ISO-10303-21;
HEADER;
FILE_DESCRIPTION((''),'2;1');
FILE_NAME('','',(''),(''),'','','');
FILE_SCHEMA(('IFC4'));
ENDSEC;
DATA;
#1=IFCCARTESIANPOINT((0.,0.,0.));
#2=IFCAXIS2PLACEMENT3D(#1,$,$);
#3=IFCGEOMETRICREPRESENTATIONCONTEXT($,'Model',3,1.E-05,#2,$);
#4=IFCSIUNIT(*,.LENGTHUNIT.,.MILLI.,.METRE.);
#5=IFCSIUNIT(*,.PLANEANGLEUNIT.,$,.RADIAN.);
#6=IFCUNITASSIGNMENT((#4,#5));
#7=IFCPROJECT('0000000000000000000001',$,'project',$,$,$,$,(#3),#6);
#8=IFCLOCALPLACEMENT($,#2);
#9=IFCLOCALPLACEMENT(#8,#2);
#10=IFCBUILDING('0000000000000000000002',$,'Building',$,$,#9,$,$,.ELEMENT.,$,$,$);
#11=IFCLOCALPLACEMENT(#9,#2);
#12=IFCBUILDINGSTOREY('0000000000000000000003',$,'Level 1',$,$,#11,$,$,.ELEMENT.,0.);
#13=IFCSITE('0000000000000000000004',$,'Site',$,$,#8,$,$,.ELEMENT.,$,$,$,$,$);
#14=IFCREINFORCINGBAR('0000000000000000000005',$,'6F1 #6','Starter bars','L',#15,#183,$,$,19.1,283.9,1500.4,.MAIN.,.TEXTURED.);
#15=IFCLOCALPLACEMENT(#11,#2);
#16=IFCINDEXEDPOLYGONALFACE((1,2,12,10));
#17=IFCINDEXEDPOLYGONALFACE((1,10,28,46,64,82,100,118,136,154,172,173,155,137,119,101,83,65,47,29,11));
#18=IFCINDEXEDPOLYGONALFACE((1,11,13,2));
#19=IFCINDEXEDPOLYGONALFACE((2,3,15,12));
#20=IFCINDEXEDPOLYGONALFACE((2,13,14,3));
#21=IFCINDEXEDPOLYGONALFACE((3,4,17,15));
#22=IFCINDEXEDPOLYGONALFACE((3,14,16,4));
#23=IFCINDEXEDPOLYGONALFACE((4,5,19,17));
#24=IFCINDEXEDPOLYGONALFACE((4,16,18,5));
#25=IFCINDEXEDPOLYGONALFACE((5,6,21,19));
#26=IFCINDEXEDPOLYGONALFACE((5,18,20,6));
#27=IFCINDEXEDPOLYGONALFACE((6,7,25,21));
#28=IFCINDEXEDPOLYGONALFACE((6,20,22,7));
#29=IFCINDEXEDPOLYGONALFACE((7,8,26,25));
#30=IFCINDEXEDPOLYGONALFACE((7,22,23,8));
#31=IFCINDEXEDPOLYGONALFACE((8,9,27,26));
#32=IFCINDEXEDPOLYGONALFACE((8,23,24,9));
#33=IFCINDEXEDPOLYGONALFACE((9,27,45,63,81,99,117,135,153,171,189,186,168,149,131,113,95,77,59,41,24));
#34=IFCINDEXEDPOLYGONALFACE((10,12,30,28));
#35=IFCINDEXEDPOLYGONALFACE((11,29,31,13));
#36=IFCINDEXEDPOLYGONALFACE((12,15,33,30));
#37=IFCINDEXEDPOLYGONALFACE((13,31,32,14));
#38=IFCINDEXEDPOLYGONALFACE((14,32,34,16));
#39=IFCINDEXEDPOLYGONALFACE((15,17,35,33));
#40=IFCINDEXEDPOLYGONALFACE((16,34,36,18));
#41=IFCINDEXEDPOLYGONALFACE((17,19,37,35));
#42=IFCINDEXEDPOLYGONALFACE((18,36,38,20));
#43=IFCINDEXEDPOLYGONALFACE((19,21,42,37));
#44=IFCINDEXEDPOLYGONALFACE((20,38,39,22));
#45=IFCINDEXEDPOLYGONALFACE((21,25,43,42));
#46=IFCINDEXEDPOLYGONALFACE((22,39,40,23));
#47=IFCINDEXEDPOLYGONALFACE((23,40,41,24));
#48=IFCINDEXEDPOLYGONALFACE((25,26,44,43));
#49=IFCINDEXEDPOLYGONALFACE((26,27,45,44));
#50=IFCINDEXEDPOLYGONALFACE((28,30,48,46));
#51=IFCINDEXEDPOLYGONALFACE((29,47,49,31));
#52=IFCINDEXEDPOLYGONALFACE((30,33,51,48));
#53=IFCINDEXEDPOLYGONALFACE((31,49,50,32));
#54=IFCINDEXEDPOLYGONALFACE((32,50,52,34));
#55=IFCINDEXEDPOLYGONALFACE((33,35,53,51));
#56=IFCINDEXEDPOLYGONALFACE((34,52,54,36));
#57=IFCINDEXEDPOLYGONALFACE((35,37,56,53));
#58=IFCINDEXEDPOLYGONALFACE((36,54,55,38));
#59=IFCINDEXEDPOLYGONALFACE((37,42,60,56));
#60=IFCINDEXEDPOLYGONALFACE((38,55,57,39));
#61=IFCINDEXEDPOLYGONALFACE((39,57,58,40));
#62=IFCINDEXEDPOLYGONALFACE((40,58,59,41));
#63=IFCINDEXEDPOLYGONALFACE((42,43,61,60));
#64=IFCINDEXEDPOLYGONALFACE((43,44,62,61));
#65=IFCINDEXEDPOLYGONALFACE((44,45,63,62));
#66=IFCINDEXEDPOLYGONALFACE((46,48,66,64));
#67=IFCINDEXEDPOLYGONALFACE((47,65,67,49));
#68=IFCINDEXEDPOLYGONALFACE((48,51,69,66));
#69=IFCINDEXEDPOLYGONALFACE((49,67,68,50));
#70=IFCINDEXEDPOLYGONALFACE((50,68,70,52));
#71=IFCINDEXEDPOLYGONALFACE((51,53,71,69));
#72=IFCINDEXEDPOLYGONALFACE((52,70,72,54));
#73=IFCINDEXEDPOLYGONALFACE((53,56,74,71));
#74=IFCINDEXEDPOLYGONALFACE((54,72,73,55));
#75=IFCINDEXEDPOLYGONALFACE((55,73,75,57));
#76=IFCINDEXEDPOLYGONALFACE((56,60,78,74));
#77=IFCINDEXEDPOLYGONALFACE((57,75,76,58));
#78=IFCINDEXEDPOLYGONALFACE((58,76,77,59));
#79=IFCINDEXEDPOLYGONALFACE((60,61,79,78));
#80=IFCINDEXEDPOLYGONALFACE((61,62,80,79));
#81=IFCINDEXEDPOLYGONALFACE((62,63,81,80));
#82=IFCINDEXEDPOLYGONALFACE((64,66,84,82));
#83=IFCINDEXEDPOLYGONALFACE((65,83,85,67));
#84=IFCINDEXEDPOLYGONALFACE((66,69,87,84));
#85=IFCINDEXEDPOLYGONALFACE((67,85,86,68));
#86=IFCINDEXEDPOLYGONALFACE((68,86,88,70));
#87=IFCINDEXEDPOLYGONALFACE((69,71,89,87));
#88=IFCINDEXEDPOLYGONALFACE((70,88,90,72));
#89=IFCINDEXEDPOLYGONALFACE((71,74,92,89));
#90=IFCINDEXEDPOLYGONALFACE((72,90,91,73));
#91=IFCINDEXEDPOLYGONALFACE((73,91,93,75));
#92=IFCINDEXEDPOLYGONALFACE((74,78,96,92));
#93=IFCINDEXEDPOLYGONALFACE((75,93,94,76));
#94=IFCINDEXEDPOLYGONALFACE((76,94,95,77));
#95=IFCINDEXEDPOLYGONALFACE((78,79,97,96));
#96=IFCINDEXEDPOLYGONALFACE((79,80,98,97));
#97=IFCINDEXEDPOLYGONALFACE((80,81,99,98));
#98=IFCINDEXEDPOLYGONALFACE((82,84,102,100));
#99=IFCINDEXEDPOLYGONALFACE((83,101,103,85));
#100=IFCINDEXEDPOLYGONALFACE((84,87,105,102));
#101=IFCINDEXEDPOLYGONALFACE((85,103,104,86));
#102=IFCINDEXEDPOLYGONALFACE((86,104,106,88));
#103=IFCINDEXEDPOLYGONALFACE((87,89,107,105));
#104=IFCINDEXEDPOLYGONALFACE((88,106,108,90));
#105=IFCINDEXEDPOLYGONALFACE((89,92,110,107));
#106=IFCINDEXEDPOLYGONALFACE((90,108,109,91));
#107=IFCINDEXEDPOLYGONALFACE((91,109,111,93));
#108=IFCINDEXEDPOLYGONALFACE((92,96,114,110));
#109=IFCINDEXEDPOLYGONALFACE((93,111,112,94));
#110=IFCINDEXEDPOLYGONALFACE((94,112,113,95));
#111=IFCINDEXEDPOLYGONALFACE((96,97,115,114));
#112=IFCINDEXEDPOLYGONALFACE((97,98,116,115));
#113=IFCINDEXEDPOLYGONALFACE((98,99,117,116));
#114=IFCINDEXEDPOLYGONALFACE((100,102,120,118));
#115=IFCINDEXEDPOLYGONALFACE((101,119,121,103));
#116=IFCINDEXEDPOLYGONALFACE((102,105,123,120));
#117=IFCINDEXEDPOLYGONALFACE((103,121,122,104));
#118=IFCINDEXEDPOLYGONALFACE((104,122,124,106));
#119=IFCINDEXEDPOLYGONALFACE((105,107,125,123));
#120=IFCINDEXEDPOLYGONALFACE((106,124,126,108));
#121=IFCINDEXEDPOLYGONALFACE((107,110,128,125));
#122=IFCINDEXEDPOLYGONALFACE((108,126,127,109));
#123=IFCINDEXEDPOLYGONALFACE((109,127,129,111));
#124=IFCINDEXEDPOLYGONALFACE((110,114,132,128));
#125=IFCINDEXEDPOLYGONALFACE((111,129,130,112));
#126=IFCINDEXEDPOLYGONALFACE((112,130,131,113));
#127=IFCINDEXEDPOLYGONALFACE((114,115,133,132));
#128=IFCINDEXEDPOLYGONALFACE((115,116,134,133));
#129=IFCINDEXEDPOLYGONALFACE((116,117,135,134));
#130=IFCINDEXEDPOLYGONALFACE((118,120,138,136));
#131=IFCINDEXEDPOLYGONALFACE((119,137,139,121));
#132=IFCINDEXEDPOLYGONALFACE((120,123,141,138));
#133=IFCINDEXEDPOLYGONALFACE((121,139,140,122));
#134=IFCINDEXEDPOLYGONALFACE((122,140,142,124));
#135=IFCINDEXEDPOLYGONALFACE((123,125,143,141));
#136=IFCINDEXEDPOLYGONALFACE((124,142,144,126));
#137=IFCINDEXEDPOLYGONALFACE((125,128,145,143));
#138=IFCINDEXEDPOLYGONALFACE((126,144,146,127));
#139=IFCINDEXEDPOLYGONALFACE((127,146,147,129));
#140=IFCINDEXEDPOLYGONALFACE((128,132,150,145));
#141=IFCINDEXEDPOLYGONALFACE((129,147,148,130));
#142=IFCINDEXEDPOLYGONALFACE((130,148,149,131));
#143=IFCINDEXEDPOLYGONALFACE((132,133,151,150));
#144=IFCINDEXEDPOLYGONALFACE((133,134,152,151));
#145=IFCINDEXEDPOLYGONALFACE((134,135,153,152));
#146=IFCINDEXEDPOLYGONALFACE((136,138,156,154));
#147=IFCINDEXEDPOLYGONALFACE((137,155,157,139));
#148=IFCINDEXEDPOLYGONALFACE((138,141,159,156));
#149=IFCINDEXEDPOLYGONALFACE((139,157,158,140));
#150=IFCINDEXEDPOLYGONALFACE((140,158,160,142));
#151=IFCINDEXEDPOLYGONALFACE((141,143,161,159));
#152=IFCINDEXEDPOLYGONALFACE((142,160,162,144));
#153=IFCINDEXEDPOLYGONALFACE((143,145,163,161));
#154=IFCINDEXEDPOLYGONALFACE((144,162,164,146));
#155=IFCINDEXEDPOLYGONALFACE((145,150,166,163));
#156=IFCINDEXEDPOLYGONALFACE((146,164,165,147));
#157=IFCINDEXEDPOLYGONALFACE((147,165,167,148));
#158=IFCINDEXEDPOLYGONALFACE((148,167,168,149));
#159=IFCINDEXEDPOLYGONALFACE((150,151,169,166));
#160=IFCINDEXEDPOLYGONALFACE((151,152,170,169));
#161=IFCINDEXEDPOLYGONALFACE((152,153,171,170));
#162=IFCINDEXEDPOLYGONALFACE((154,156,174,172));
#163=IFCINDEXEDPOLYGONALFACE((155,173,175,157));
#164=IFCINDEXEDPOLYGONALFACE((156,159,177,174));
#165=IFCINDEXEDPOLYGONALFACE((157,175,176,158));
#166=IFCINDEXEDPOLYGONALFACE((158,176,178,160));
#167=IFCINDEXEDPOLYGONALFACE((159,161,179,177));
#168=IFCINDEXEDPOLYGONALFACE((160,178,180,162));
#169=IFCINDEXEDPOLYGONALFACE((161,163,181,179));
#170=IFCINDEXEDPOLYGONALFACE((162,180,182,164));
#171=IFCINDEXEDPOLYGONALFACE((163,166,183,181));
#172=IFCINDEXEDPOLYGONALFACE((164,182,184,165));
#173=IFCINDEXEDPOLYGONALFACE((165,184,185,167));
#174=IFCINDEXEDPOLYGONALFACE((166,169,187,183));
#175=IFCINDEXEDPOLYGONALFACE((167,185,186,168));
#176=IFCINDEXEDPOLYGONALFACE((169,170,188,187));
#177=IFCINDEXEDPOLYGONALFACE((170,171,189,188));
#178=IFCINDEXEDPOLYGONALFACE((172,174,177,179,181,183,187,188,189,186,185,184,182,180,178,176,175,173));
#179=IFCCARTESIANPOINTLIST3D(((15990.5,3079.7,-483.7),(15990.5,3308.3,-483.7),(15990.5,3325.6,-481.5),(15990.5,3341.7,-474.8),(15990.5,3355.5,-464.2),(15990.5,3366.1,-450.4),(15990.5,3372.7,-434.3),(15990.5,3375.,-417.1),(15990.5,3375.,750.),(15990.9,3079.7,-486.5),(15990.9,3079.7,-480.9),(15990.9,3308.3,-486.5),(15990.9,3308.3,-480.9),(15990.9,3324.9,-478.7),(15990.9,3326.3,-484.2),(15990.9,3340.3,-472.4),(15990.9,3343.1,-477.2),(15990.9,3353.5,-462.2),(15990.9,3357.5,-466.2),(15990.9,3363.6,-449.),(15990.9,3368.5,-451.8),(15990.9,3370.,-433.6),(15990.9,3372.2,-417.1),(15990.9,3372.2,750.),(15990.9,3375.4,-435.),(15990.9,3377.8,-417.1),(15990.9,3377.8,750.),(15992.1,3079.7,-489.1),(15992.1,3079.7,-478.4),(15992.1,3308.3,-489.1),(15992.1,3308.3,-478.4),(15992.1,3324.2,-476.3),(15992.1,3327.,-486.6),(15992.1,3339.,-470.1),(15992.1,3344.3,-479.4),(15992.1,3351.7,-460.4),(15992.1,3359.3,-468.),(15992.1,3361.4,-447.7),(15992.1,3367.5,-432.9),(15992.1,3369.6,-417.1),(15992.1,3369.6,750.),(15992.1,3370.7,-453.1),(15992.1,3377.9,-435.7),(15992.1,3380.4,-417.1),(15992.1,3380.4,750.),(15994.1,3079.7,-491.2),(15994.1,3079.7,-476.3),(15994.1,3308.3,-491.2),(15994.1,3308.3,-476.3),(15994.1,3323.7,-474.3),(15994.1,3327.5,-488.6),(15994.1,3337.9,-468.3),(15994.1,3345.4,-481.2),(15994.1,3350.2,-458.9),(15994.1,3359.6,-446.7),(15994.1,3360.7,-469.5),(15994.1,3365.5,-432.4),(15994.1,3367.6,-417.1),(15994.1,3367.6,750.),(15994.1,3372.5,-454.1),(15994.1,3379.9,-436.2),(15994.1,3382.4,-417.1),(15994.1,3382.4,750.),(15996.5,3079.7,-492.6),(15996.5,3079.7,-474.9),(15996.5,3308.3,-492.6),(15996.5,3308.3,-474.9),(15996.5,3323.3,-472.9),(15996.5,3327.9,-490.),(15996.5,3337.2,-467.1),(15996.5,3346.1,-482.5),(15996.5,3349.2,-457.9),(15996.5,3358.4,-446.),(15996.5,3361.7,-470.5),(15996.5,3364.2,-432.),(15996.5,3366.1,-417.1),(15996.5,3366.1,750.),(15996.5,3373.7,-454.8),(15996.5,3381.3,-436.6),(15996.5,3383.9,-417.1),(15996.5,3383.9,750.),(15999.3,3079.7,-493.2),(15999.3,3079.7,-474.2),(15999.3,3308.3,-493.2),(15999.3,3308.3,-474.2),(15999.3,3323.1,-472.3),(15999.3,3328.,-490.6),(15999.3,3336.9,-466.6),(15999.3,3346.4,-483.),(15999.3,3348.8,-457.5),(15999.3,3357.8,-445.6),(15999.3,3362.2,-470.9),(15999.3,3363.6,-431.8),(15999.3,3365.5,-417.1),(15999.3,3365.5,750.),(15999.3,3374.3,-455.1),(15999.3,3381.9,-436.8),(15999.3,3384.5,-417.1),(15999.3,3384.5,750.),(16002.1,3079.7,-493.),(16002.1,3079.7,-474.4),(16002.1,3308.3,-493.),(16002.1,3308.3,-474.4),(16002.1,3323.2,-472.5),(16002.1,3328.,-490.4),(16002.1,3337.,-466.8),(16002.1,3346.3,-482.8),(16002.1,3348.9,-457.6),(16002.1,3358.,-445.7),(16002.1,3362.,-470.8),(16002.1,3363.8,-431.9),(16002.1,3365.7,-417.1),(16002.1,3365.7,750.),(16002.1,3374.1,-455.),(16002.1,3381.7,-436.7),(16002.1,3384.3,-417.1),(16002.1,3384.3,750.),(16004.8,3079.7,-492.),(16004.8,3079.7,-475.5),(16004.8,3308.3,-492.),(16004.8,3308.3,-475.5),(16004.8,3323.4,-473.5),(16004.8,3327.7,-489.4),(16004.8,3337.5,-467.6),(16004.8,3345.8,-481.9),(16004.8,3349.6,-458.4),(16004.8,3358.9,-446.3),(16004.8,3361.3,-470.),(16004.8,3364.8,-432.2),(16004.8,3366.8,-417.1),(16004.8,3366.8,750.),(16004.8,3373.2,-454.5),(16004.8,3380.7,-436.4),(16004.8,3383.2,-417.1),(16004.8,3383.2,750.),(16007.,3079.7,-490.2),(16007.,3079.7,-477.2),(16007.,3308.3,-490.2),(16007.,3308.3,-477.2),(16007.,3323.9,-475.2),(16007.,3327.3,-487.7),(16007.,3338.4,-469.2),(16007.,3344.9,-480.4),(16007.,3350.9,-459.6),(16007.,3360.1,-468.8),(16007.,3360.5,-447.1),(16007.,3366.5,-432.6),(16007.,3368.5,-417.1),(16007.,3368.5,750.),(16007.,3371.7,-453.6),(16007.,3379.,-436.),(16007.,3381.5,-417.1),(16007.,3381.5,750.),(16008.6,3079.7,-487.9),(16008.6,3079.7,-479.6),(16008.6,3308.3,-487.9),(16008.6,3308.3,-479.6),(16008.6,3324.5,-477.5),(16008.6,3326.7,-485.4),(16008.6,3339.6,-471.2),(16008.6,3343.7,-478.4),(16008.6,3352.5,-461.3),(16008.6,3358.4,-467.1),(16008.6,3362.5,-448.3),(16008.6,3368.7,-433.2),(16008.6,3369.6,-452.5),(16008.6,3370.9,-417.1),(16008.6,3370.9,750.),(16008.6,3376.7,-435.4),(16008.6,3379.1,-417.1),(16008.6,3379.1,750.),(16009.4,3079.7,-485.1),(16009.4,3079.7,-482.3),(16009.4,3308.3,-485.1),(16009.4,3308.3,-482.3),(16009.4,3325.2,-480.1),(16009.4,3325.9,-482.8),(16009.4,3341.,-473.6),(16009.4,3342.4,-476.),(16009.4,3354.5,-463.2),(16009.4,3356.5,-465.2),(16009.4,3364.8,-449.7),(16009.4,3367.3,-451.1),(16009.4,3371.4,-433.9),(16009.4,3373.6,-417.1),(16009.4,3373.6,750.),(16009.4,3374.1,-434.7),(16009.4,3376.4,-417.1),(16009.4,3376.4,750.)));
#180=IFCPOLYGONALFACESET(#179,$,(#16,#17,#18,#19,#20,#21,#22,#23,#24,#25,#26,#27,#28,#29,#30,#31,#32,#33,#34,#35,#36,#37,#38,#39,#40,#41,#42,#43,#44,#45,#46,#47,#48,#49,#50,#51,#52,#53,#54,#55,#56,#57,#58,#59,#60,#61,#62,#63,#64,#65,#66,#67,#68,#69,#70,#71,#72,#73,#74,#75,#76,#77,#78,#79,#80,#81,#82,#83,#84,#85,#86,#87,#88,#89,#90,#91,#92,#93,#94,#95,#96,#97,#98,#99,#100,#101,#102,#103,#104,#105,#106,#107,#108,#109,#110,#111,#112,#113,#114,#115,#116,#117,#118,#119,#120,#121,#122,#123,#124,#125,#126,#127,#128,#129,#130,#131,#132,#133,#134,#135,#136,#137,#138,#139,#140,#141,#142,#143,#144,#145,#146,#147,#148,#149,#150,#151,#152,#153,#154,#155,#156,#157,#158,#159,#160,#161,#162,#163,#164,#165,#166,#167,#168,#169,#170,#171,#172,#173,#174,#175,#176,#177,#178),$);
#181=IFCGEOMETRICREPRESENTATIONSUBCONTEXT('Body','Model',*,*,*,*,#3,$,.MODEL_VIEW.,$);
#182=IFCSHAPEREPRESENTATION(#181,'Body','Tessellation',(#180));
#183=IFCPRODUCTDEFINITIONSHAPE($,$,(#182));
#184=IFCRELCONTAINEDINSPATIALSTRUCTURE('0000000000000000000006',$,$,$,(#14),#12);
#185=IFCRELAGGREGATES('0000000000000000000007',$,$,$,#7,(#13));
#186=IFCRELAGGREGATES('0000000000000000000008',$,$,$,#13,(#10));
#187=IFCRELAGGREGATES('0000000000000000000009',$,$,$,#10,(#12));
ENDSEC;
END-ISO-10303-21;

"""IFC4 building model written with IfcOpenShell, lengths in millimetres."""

from ifc_helpers import new_model, entity, si_unit, origin, place, context, subcontext, project, spatial, element, save


model = new_model("IFC4")

# Units and contexts
model_context = context("Model", 3, precision=1e-05, world=origin())
body_context = subcontext(model_context, "Body", "Model", "MODEL_VIEW")
ifc_project = project(units=[si_unit("LENGTHUNIT", "METRE", prefix="MILLI"), si_unit("PLANEANGLEUNIT", "RADIAN")], contexts=[model_context])

# Site, building, storey
site_placement = place(None, origin())
site = spatial("IfcSite", under=ifc_project, at=site_placement, Name="Site", CompositionType="ELEMENT")
building_placement = place(site_placement, origin())
building = spatial("IfcBuilding", under=site, at=building_placement, Name="Building", CompositionType="ELEMENT")
storey_placement = place(building_placement, origin())
storey = spatial("IfcBuildingStorey", under=building, at=storey_placement, Name="Level 1", CompositionType="ELEMENT", Elevation=0.0)

# Reinforcing bar
reinforcing_bar_1_placement = place(storey_placement, origin())
element("IfcReinforcingBar", 1, at=reinforcing_bar_1_placement, inside=storey, Name="6F1 #6", Description="Starter bars", ObjectType="L", BarLength=1500.4, BarSurface="TEXTURED", CrossSectionArea=283.9, NominalDiameter=19.1, PredefinedType="MAIN", context=body_context, shape_type="AdvancedSweptSolid", body=[
    entity("IfcSweptDiskSolid", entity("IfcIndexedPolyCurve", entity("IfcCartesianPointList3D", [[16000.0, 3375.0, 750.0], [16000.0, 3375.0, -417.1], [16000.0, 3355.5, -464.2], [16000.0, 3308.3, -483.7], [16000.0, 3079.7, -483.7]]), [entity("IfcLineIndex", [1, 2]), entity("IfcArcIndex", [2, 3, 4]), entity("IfcLineIndex", [4, 5])], False), 9.5),
])

save(model, "model.ifc")
